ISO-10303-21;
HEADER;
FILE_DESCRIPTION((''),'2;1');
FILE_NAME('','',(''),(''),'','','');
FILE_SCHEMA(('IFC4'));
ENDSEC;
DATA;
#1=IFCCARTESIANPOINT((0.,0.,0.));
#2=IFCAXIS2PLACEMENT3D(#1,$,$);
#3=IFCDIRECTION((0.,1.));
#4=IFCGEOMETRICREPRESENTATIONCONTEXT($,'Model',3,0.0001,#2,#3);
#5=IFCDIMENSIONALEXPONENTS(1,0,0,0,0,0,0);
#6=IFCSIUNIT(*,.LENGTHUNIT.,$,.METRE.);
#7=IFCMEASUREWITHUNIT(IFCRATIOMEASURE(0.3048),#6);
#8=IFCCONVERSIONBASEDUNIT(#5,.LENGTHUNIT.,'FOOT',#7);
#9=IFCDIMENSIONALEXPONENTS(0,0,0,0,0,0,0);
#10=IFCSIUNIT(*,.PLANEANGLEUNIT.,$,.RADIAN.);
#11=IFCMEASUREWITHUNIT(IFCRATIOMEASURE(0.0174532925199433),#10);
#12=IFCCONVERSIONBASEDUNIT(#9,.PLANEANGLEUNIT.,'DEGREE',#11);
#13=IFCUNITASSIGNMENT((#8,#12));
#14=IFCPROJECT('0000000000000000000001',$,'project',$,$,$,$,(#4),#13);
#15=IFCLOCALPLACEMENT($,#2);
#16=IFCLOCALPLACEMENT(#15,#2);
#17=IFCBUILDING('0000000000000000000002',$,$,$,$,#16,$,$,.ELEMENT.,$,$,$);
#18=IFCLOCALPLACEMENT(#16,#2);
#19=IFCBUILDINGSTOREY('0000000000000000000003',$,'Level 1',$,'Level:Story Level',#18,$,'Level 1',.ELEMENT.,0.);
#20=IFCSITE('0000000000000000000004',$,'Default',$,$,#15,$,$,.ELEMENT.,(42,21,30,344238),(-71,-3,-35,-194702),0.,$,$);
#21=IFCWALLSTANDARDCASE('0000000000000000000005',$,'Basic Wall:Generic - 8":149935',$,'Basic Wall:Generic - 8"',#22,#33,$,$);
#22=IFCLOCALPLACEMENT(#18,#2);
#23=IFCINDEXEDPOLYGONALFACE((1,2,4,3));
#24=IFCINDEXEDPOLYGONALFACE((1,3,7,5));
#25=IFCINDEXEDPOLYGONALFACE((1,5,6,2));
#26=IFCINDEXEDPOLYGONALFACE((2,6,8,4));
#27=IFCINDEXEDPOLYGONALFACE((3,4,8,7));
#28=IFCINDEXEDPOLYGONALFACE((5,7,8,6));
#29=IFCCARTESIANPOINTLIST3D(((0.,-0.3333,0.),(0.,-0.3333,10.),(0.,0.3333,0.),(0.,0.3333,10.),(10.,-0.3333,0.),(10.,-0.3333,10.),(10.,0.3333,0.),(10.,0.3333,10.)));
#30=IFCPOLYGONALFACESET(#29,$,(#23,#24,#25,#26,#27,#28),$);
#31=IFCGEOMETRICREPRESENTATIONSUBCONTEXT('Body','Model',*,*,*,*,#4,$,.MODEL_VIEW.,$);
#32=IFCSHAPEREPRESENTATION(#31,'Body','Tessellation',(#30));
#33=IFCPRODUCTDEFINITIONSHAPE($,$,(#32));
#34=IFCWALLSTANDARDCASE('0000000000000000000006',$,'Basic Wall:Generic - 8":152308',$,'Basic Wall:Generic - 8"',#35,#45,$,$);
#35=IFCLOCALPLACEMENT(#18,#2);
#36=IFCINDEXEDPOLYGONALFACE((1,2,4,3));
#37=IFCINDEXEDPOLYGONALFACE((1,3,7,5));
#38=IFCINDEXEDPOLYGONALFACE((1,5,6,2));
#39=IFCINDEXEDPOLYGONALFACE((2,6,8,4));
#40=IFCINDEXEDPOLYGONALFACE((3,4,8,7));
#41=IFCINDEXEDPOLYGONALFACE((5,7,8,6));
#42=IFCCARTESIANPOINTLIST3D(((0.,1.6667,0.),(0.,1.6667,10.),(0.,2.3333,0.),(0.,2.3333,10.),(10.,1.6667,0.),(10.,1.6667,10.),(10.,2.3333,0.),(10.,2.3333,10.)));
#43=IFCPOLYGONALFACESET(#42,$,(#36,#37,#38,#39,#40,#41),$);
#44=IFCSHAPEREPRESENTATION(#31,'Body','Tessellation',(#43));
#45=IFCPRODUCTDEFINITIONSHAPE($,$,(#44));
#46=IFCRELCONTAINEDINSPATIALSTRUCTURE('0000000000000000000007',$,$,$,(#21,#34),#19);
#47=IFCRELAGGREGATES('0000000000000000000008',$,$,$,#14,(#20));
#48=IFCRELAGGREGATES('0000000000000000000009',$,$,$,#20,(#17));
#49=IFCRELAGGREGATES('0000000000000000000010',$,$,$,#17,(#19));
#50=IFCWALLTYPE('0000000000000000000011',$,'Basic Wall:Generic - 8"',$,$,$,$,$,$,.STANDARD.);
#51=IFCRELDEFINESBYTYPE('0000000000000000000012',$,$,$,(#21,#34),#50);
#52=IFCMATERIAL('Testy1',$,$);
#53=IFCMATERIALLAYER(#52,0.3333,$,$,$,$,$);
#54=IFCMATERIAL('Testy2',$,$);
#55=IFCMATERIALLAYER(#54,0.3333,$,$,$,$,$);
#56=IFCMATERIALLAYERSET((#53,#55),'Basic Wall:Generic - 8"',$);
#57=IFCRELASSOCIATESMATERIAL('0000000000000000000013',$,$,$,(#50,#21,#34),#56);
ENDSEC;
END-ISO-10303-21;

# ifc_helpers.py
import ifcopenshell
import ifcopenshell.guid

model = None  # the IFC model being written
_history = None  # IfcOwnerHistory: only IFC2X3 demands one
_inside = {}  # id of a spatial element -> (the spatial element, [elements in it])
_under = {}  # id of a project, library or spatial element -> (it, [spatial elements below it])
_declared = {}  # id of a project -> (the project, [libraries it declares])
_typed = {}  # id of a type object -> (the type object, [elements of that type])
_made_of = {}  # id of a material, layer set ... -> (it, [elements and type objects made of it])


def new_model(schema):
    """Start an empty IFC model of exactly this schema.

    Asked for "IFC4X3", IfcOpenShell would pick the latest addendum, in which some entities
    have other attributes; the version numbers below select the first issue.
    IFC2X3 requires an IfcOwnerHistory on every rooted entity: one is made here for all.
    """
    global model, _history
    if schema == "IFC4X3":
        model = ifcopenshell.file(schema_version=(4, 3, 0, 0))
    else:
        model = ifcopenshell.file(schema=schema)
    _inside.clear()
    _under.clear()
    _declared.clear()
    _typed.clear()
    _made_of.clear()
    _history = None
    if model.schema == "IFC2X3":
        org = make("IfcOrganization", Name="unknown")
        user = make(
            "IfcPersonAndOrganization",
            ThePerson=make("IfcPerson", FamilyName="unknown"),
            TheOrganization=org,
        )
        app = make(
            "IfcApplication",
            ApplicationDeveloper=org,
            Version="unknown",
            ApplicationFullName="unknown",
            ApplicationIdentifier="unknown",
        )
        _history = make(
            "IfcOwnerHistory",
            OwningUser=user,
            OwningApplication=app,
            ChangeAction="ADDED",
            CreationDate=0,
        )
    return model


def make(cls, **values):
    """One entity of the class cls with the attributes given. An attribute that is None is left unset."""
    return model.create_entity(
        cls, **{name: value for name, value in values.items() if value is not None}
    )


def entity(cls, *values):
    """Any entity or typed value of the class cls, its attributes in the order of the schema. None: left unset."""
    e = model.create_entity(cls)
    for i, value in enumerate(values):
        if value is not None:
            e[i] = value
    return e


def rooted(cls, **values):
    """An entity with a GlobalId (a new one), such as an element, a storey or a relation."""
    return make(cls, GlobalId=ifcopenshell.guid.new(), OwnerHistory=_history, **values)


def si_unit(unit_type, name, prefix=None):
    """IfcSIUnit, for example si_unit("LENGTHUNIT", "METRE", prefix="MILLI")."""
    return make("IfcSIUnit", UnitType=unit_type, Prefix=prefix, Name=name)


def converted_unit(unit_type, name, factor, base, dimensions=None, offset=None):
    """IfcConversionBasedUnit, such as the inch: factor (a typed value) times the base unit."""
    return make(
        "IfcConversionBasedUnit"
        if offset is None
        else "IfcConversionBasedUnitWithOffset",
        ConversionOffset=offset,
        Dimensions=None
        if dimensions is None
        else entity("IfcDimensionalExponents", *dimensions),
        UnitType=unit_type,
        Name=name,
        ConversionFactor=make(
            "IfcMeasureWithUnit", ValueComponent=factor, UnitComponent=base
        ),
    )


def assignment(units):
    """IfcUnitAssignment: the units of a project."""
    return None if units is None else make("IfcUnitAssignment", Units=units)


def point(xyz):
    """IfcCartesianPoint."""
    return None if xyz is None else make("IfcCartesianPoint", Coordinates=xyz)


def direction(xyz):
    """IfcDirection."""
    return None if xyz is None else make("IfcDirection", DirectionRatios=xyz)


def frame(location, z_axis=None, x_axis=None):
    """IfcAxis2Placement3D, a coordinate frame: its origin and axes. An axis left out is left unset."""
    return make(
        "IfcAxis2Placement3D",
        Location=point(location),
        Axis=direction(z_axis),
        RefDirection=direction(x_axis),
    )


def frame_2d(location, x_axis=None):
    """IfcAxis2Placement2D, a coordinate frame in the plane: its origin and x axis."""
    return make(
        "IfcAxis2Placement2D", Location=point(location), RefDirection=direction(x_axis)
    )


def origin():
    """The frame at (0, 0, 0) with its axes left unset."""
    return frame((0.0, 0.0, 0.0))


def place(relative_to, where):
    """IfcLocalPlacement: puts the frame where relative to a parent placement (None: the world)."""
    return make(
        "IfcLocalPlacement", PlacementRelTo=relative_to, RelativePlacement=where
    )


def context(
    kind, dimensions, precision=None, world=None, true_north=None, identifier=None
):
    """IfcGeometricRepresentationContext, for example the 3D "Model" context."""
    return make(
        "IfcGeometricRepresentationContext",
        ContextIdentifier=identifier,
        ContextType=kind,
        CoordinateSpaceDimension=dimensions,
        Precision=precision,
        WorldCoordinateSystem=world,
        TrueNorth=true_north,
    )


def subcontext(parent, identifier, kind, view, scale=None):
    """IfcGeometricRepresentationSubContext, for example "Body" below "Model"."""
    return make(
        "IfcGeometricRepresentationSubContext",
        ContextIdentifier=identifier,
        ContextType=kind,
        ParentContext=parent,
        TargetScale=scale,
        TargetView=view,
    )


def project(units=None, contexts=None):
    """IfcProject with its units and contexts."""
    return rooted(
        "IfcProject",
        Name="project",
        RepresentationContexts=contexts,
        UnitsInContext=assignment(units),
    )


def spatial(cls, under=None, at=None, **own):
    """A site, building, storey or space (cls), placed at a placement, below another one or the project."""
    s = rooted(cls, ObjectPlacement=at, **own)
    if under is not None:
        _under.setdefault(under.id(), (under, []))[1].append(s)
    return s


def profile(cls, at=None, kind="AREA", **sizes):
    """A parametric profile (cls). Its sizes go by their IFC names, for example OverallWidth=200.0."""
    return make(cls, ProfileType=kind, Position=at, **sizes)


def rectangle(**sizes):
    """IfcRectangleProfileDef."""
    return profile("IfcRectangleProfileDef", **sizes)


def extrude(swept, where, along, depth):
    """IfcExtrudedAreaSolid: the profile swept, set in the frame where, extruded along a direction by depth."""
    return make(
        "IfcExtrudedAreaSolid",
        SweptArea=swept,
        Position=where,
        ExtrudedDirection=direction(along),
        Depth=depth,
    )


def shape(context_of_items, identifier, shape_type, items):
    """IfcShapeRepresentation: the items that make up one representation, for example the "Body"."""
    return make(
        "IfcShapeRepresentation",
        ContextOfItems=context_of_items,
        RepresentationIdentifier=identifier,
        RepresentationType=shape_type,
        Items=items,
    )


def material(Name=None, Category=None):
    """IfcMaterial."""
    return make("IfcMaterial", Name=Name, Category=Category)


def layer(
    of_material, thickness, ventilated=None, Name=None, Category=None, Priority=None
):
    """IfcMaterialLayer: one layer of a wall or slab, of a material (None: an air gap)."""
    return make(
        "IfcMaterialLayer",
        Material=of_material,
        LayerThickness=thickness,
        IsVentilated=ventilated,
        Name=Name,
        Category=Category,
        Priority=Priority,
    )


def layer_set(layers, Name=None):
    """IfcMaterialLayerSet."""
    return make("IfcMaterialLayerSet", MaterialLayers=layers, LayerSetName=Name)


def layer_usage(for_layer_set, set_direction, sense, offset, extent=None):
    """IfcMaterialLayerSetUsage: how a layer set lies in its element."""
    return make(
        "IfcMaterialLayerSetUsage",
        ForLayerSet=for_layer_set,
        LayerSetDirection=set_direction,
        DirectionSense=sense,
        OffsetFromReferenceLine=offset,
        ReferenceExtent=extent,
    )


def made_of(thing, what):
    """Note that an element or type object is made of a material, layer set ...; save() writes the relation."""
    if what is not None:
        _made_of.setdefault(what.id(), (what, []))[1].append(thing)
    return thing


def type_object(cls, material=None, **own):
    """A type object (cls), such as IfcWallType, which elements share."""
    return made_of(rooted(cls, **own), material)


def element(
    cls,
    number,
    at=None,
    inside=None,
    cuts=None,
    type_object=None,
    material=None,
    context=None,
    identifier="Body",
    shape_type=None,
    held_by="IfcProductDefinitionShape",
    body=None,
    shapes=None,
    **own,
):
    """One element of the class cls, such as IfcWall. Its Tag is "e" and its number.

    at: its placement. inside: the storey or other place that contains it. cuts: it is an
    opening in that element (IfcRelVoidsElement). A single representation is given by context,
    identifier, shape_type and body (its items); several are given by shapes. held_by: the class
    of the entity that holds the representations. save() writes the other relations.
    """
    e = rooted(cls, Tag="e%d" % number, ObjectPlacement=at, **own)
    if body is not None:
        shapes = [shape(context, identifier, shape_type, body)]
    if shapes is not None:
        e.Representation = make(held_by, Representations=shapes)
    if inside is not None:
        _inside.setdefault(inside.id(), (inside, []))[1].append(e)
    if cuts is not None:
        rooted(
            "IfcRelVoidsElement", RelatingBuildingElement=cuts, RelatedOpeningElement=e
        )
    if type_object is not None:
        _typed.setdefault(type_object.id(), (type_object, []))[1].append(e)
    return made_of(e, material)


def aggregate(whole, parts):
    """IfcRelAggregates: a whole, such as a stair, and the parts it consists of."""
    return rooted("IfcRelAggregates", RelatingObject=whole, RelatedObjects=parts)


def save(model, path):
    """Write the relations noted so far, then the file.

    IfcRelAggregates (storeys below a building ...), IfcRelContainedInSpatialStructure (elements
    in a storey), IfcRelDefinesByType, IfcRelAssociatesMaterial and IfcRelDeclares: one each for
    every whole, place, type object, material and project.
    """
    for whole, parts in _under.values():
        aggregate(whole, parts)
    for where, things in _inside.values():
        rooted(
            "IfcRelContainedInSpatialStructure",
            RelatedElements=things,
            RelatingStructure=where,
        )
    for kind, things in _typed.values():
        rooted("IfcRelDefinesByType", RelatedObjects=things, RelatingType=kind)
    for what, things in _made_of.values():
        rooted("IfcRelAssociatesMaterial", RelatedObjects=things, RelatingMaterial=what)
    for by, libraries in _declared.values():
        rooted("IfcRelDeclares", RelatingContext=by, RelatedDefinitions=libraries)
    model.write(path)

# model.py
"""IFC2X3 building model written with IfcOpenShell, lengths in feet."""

from ifc_helpers import new_model, entity, si_unit, converted_unit, direction, frame, frame_2d, origin, place, context, subcontext, project, spatial, rectangle, extrude, material, layer, layer_set, layer_usage, type_object, element, save


model = new_model("IFC2X3")

# Units and contexts
model_context = context("Model", 3, precision=0.0001, world=origin(), true_north=direction((0.0, 1.0)))
body_context = subcontext(model_context, "Body", "Model", "MODEL_VIEW")
ifc_project = project(units=[converted_unit("LENGTHUNIT", "FOOT", entity("IfcRatioMeasure", 0.3048), si_unit("LENGTHUNIT", "METRE"), dimensions=[1, 0, 0, 0, 0, 0, 0]), converted_unit("PLANEANGLEUNIT", "DEGREE", entity("IfcRatioMeasure", 0.0174532925199433), si_unit("PLANEANGLEUNIT", "RADIAN"), dimensions=[0, 0, 0, 0, 0, 0, 0])], contexts=[model_context])

# Site, building, storey
site_placement = place(None, origin())
site = spatial("IfcSite", under=ifc_project, at=site_placement, Name="Default", CompositionType="ELEMENT", RefLatitude=(42, 21, 30, 344238), RefLongitude=(-71, -3, -35, -194702), RefElevation=0.0)
building_placement = place(site_placement, origin())
building = spatial("IfcBuilding", under=site, at=building_placement, CompositionType="ELEMENT")
storey_placement = place(building_placement, origin())
storey = spatial("IfcBuildingStorey", under=building, at=storey_placement, Name="Level 1", ObjectType="Level:Story Level", LongName="Level 1", CompositionType="ELEMENT", Elevation=0.0)

# Walls
ifc_material_1 = material(Name="Testy1")
ifc_layer_1 = layer(ifc_material_1, 0.3333)
ifc_material_2 = material(Name="Testy2")
ifc_layer_2 = layer(ifc_material_2, 0.3333)
ifc_layer_set = layer_set([ifc_layer_1, ifc_layer_2], Name="Basic Wall:Generic - 8\"")
ifc_layer_usage_1 = layer_usage(ifc_layer_set, "AXIS2", "NEGATIVE", 0.3333)
wall_type = type_object("IfcWallType", Name="Basic Wall:Generic - 8\"", PredefinedType="STANDARD", material=ifc_layer_set)
wall_1_placement = place(storey_placement, origin())
element("IfcWallStandardCase", 1, at=wall_1_placement, inside=storey, type_object=wall_type, material=ifc_layer_usage_1, Name="Basic Wall:Generic - 8\":149935", ObjectType="Basic Wall:Generic - 8\"", context=body_context, shape_type="SweptSolid", body=[
    extrude(rectangle(XDim=10.0, YDim=0.6667, at=frame_2d((5.0, 0.0), x_axis=(-1.0, 0.0))), origin(), (0.0, 0.0, 1.0), 10.0),
])
ifc_layer_usage_2 = layer_usage(ifc_layer_set, "AXIS2", "NEGATIVE", 0.3333)
wall_2_placement = place(storey_placement, frame((0.0, 2.0, 0.0)))
element("IfcWallStandardCase", 2, at=wall_2_placement, inside=storey, type_object=wall_type, material=ifc_layer_usage_2, Name="Basic Wall:Generic - 8\":152308", ObjectType="Basic Wall:Generic - 8\"", context=body_context, shape_type="SweptSolid", body=[
    extrude(rectangle(XDim=10.0, YDim=0.6667, at=frame_2d((5.0, 0.0), x_axis=(-1.0, 0.0))), origin(), (0.0, 0.0, 1.0), 10.0),
])

save(model, "model.ifc")
